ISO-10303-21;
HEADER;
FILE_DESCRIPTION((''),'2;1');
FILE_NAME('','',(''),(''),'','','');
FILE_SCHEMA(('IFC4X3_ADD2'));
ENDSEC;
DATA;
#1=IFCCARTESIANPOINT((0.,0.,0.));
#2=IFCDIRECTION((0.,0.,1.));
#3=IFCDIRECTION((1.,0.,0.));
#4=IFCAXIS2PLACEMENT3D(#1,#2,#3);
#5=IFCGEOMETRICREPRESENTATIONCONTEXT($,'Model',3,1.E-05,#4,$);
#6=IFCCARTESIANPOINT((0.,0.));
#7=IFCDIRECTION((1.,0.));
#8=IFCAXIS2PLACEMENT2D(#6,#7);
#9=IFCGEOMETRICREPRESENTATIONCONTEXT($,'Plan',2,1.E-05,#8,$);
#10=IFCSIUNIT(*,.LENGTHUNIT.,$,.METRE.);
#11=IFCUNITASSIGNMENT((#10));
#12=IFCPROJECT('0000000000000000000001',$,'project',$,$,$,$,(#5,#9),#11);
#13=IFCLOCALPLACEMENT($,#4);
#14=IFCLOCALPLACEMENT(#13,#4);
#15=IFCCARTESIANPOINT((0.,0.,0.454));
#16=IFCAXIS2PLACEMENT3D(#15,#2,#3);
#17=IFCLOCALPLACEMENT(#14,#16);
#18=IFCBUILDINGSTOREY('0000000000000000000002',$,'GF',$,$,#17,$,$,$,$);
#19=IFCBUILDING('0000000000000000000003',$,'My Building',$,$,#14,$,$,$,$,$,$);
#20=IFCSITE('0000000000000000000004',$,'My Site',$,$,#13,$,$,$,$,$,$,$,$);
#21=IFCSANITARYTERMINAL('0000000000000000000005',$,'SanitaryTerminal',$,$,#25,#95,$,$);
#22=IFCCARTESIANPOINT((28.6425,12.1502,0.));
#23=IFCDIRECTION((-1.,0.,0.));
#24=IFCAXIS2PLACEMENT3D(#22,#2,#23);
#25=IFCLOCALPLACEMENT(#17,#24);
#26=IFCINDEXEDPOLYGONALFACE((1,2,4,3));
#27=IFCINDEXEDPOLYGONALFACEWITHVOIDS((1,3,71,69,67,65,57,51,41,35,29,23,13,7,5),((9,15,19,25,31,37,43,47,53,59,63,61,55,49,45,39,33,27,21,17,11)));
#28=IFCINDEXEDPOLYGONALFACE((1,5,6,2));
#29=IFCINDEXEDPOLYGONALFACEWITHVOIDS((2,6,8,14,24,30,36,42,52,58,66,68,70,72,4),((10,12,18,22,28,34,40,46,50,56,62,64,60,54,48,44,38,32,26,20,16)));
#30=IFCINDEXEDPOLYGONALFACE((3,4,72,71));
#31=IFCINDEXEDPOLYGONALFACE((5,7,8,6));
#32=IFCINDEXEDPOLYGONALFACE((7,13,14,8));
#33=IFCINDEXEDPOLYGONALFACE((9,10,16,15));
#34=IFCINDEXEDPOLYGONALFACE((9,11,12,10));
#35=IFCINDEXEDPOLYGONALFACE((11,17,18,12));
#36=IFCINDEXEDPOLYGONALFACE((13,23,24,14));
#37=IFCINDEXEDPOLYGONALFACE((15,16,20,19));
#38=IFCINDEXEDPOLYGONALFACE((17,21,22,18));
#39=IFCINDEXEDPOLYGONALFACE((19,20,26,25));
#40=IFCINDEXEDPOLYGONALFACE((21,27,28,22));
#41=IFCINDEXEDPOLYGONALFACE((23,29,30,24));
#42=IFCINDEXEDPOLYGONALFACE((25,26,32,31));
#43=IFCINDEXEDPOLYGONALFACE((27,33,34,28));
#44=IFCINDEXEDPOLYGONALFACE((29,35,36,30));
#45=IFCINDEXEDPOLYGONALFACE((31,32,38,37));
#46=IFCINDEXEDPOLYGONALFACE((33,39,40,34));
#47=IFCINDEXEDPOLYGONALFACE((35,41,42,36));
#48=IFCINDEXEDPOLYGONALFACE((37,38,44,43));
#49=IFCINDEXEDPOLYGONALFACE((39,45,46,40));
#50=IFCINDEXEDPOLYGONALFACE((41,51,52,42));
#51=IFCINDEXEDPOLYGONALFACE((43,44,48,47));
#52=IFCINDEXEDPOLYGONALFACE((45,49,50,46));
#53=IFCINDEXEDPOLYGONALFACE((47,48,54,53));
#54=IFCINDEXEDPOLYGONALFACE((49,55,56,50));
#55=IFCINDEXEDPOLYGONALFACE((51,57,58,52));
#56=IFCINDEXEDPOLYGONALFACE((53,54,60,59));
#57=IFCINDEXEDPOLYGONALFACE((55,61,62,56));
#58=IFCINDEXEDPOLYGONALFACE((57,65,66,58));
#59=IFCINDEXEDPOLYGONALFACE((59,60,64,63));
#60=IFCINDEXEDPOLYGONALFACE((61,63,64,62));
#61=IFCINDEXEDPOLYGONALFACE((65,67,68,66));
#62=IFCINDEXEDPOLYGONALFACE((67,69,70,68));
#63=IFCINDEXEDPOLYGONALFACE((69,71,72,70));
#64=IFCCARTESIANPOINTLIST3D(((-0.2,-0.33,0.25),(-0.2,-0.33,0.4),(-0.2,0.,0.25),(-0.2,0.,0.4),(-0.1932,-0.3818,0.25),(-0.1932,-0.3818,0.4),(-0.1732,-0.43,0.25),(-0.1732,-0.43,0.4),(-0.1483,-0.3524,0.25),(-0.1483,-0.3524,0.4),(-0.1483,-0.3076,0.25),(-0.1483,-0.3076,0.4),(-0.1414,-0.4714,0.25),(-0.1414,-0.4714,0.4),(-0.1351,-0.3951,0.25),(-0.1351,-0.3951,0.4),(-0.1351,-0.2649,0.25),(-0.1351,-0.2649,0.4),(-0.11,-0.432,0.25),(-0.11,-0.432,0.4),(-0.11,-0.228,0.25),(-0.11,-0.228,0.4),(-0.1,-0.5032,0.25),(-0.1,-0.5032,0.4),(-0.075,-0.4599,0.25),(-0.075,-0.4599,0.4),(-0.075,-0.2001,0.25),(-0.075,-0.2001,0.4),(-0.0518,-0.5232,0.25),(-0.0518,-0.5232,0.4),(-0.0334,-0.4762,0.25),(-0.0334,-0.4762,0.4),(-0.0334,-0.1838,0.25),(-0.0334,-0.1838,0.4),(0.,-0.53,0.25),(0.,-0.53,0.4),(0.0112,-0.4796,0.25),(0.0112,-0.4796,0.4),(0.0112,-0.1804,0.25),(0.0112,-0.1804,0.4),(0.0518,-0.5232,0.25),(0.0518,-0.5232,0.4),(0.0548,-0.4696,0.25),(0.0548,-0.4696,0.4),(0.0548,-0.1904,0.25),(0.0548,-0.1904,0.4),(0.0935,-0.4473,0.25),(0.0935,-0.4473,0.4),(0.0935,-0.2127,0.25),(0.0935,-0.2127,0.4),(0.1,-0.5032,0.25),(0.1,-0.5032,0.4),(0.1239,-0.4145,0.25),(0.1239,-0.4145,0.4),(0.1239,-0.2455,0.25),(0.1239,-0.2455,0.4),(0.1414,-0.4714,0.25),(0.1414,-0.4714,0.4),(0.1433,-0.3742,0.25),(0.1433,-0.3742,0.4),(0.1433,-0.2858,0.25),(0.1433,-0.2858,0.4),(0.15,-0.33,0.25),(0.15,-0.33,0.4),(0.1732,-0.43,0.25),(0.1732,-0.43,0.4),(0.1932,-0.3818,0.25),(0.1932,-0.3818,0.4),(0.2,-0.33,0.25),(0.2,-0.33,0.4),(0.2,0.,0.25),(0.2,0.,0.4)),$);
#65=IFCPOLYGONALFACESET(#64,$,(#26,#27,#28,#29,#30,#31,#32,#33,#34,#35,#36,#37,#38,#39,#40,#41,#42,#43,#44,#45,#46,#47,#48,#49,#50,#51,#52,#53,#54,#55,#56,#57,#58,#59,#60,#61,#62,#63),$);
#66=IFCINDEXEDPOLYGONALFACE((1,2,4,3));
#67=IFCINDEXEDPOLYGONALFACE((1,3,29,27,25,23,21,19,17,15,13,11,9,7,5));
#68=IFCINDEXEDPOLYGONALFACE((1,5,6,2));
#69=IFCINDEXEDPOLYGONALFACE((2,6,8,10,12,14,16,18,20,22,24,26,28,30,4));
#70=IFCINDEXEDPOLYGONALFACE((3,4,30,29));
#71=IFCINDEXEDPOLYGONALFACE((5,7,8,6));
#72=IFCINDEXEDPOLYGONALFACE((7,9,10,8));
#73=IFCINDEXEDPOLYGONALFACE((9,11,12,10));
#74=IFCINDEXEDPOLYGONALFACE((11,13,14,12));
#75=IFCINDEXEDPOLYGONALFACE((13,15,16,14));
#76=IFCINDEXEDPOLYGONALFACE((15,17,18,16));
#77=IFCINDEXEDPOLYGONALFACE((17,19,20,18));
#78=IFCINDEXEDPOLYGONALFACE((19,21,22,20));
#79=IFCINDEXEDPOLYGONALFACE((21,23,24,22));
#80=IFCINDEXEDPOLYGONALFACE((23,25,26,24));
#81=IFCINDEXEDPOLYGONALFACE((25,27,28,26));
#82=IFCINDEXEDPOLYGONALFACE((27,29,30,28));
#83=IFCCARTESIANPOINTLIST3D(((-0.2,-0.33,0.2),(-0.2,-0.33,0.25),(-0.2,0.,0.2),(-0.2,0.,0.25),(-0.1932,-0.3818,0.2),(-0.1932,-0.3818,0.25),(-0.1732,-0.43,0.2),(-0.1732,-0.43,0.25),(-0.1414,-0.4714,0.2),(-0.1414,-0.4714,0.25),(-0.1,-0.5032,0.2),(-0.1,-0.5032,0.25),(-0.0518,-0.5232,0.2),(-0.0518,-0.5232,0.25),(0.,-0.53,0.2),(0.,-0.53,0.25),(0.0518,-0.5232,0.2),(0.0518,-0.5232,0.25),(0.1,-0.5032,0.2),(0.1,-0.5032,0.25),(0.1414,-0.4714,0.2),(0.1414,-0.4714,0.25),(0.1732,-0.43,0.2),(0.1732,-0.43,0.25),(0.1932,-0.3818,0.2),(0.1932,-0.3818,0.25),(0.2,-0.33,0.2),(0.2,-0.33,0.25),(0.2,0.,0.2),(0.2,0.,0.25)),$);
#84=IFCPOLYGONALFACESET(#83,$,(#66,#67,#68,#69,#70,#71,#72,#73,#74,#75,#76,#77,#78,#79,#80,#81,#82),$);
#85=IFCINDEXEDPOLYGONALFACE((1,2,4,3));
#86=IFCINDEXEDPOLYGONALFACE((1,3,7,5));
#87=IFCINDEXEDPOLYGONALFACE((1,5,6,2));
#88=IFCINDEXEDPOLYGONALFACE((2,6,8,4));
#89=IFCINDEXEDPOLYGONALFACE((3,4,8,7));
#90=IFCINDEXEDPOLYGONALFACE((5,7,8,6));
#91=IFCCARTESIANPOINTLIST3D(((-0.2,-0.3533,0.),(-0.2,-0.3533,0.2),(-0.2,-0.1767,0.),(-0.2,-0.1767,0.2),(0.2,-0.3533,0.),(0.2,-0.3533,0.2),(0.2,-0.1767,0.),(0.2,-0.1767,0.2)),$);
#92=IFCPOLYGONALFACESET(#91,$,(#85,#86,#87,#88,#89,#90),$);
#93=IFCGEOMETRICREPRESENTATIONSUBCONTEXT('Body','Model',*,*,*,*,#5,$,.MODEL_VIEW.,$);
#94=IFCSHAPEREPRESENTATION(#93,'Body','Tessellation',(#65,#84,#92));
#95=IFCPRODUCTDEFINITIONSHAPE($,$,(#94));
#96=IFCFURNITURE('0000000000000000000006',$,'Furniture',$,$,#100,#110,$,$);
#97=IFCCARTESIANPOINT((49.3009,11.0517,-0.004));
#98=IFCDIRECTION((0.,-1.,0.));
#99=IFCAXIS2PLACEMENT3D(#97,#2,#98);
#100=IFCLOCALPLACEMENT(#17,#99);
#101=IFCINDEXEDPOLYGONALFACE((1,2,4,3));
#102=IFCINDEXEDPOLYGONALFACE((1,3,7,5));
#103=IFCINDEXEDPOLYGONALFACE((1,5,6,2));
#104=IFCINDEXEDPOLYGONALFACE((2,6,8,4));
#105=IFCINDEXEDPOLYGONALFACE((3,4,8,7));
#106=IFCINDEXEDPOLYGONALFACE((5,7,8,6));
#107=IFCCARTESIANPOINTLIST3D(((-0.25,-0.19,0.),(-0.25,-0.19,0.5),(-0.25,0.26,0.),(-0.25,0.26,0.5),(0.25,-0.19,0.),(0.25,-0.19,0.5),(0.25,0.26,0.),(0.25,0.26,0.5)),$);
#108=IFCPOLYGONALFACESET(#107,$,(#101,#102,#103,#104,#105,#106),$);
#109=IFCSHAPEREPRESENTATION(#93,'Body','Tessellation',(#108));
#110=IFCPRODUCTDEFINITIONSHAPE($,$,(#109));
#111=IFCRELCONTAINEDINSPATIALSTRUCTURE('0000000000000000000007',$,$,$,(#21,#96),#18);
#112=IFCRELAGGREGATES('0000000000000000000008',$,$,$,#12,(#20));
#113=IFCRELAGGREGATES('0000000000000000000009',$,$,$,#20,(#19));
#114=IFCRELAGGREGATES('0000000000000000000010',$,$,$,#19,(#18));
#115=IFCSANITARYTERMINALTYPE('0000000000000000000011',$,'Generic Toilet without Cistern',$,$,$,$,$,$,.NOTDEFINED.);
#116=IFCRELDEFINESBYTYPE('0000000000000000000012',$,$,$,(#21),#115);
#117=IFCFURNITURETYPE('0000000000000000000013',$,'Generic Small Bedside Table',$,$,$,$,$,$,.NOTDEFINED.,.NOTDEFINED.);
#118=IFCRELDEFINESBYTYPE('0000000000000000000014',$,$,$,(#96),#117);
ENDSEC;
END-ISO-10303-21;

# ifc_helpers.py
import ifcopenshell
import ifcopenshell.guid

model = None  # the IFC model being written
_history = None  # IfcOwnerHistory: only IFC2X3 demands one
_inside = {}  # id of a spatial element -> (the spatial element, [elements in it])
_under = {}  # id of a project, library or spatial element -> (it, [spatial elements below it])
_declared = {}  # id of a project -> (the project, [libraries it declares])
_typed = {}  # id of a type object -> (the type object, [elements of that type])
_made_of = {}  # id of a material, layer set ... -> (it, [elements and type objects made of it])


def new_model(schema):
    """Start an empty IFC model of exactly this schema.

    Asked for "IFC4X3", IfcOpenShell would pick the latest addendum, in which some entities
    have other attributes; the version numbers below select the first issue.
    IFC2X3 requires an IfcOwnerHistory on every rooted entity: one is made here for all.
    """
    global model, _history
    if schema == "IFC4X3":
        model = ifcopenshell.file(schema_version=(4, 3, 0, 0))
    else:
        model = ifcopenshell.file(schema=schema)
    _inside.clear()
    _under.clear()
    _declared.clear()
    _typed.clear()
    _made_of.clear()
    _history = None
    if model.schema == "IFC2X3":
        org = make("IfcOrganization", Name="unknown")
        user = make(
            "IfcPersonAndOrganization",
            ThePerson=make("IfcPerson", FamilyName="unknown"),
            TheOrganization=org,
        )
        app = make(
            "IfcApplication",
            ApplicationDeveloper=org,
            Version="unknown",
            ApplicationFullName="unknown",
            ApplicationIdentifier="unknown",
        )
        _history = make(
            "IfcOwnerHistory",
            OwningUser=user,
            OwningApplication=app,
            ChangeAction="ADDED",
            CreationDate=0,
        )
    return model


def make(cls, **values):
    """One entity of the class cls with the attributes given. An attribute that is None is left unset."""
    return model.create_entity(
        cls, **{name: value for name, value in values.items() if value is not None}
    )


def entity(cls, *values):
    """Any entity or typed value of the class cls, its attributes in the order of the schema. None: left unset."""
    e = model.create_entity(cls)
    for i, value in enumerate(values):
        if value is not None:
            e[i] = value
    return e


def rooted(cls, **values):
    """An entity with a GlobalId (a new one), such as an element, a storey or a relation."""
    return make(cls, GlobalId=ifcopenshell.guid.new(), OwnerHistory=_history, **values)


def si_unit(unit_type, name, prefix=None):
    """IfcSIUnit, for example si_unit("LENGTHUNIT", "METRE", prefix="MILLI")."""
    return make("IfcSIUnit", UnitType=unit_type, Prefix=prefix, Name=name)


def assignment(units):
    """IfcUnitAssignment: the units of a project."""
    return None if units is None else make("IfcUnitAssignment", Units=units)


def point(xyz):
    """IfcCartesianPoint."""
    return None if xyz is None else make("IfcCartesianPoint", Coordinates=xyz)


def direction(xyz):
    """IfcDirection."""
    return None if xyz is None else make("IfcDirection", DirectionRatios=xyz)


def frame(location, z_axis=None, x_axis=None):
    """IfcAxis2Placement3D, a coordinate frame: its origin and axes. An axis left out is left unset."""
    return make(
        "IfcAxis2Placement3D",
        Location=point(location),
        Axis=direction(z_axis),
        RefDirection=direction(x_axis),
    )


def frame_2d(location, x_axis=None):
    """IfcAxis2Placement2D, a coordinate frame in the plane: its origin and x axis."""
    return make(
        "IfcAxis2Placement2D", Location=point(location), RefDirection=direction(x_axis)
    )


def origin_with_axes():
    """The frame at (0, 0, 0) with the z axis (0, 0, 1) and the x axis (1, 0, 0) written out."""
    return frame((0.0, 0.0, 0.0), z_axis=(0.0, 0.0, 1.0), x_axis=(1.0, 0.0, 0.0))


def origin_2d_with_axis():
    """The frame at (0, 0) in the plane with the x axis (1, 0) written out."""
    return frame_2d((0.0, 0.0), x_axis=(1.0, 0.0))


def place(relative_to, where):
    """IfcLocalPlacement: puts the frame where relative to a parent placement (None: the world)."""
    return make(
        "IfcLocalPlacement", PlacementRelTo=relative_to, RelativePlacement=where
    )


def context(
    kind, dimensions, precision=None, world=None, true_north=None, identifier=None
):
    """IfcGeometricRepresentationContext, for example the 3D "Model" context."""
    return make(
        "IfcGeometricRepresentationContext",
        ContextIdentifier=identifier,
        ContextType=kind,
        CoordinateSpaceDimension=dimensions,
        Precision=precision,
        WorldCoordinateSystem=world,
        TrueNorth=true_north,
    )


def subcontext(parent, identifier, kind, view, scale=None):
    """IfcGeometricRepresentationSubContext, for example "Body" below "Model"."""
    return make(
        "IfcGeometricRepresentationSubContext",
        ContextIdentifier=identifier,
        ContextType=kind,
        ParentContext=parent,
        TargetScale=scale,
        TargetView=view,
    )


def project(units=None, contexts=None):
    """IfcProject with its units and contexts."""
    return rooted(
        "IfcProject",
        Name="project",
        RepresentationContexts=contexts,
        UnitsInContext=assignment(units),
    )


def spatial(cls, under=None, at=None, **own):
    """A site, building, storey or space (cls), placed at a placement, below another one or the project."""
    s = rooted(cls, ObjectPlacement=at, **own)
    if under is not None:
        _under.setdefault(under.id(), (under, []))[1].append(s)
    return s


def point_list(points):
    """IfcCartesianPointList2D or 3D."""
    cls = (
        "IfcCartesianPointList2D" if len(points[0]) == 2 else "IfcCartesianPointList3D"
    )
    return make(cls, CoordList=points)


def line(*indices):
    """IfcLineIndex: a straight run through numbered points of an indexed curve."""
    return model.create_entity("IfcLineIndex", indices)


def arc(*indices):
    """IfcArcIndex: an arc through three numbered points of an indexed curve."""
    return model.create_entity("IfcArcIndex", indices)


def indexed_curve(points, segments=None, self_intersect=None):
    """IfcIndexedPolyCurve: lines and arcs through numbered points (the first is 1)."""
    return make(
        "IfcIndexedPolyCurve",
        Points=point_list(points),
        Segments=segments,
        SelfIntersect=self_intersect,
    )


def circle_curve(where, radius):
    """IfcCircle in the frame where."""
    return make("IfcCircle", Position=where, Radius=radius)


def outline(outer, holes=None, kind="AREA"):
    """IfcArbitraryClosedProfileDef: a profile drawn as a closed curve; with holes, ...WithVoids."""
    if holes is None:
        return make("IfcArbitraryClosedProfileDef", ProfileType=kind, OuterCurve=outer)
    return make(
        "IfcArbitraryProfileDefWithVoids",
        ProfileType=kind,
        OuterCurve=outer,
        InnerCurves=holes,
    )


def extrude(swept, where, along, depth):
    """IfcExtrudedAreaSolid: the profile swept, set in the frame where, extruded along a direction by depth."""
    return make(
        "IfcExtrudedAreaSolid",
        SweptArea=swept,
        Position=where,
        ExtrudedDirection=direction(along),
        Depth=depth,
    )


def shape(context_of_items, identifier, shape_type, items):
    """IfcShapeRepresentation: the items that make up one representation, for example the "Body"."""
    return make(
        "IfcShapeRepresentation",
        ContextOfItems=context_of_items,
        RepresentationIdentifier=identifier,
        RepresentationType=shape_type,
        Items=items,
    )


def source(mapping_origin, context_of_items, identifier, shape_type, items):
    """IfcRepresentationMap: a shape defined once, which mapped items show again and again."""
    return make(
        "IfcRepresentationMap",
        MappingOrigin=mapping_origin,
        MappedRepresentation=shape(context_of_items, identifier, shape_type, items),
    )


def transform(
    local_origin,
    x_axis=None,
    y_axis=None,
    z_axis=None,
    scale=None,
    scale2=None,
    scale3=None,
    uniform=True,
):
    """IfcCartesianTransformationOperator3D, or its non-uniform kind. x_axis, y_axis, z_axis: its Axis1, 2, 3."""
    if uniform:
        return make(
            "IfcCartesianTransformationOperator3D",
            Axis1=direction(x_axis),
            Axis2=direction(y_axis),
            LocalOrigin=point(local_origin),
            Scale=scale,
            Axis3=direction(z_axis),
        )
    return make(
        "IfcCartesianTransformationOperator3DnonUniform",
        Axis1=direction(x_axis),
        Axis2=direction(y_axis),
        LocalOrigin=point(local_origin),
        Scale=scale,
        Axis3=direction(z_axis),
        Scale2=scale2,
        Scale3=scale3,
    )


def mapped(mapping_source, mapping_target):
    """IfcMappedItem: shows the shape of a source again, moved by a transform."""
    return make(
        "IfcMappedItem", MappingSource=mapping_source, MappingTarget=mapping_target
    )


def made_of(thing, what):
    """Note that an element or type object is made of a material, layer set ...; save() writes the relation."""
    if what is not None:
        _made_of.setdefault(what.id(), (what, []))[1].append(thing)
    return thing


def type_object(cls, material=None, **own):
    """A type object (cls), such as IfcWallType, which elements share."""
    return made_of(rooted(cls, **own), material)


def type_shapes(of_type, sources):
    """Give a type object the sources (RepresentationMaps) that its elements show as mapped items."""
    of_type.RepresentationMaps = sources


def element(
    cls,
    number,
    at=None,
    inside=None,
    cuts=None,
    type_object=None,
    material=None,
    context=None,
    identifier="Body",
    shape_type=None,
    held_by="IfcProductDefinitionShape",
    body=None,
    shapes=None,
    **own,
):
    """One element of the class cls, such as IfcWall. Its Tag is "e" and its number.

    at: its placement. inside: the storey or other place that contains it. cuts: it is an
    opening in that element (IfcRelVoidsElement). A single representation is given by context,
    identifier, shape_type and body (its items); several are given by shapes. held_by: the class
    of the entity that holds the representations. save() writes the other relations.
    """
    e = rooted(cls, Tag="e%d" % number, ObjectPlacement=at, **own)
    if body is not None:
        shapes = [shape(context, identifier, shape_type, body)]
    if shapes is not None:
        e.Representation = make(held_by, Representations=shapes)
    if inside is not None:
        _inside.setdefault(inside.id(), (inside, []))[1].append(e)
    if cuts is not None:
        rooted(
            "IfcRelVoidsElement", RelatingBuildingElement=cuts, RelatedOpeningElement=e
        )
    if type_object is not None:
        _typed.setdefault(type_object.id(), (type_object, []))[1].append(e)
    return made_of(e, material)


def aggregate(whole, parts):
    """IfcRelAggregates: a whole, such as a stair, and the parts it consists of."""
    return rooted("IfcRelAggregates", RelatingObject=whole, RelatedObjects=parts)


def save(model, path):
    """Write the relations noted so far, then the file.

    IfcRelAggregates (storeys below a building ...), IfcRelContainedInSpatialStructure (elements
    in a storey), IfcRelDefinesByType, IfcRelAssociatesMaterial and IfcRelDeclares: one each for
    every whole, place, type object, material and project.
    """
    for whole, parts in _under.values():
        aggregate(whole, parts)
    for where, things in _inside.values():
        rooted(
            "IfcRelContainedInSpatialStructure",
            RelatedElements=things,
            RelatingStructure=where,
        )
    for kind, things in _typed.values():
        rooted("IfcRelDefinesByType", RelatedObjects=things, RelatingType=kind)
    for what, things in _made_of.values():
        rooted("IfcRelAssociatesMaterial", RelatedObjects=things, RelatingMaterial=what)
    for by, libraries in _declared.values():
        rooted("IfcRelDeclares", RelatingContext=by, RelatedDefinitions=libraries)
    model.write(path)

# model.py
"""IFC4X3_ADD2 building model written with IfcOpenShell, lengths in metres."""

from ifc_helpers import new_model, entity, si_unit, frame, frame_2d, origin_with_axes, origin_2d_with_axis, place, context, subcontext, project, spatial, line, arc, indexed_curve, circle_curve, outline, extrude, shape, source, transform, mapped, type_object, type_shapes, element, save


model = new_model("IFC4X3_ADD2")

# Units and contexts
model_context = context("Model", 3, precision=1e-05, world=origin_with_axes())
plan_context = context("Plan", 2, precision=1e-05, world=origin_2d_with_axis())
body_context_1 = subcontext(model_context, "Body", "Model", "MODEL_VIEW")
body_context_2 = subcontext(plan_context, "Body", "Plan", "PLAN_VIEW")
ifc_project = project(units=[si_unit("LENGTHUNIT", "METRE")], contexts=[model_context, plan_context])

# Site, building, storey
site_placement = place(None, origin_with_axes())
site = spatial("IfcSite", under=ifc_project, at=site_placement, Name="My Site")
building_placement = place(site_placement, origin_with_axes())
building = spatial("IfcBuilding", under=site, at=building_placement, Name="My Building")
storey_placement = place(building_placement, frame((0.0, 0.0, 0.454), z_axis=(0.0, 0.0, 1.0), x_axis=(1.0, 0.0, 0.0)))
storey = spatial("IfcBuildingStorey", under=building, at=storey_placement, Name="GF")

# Sanitary terminal
sanitary_terminal_type = type_object("IfcSanitaryTerminalType", Name="Generic Toilet without Cistern", PredefinedType="NOTDEFINED")
shared_shape_1 = source(origin_with_axes(), body_context_1, "Body", "SweptSolid", [
    extrude(outline(indexed_curve([(-0.2, 0.0), (0.2, 0.0), (0.2, -0.33), (0.1414, -0.4714), (0.0, -0.53), (-0.1414, -0.4714), (-0.2, -0.33)], segments=[line(1, 2), line(2, 3), arc(3, 4, 5), arc(5, 6, 7), line(7, 1)]), holes=[circle_curve(frame_2d((0.0, -0.33)), 0.15)]), frame((0.0, 0.0, 0.25), z_axis=(0.0, 0.0, 1.0), x_axis=(1.0, 0.0, 0.0)), (0.0, 0.0, 1.0), 0.15),
    extrude(outline(indexed_curve([(-0.2, 0.0), (0.2, 0.0), (0.2, -0.33), (0.1414, -0.4714), (0.0, -0.53), (-0.1414, -0.4714), (-0.2, -0.33)], segments=[line(1, 2), line(2, 3), arc(3, 4, 5), arc(5, 6, 7), line(7, 1)])), frame((0.0, 0.0, 0.2), z_axis=(0.0, 0.0, 1.0), x_axis=(1.0, 0.0, 0.0)), (0.0, 0.0, 1.0), 0.05),
    extrude(outline(indexed_curve([(-0.2, -0.1767), (0.2, -0.1767), (0.2, -0.3533), (-0.2, -0.3533)], segments=[line(1, 2, 3, 4, 1)])), origin_with_axes(), (0.0, 0.0, 1.0), 0.2),
])
shared_shape_2 = source(origin_with_axes(), body_context_2, "Body", "Annotation2D", [
    entity("IfcGeometricCurveSet", [entity("IfcIndexedPolyCurve", entity("IfcCartesianPointList2D", [[-0.1068, -0.124], [-0.0957, -0.1129], [-0.0804, -0.1088], [0.0804, -0.1088], [0.0957, -0.1129], [0.1068, -0.124], [0.1109, -0.1393], [0.1109, -0.3476], [0.1025, -0.3926], [0.0784, -0.4308], [0.0424, -0.4563], [0.0, -0.4652], [-0.0424, -0.4563], [-0.0784, -0.4308], [-0.1025, -0.3926], [-0.1109, -0.3476], [-0.1109, -0.1393]]), [entity("IfcLineIndex", [1, 2, 3, 4, 5, 6, 7, 8, 9, 10, 11, 12, 13, 14, 15, 16, 17, 1])]), entity("IfcIndexedPolyCurve", entity("IfcCartesianPointList2D", [[-0.1962, -0.2314], [-0.1848, -0.301], [-0.1764, -0.3339], [-0.1663, -0.3651], [-0.1546, -0.3944], [-0.1414, -0.4213], [-0.1269, -0.4458], [-0.1111, -0.4675], [-0.0943, -0.4862], [-0.0765, -0.5018], [-0.0581, -0.514], [-0.039, -0.5229], [-0.0196, -0.5282], [0.0, -0.53], [0.0196, -0.5282], [0.039, -0.5229], [0.0581, -0.514], [0.0765, -0.5018], [0.0943, -0.4862], [0.1111, -0.4675], [0.1269, -0.4458], [0.1414, -0.4213], [0.1546, -0.3944], [0.1663, -0.3651], [0.1764, -0.3339], [0.1848, -0.301], [0.1962, -0.2314], [0.2, -0.159], [0.1872, 0.0], [-0.1872, 0.0], [-0.2, -0.159]]), [entity("IfcLineIndex", [1, 2, 3, 4, 5, 6, 7, 8, 9, 10, 11, 12, 13, 14, 15, 16, 17, 18, 19, 20, 21, 22, 23, 24, 25, 26, 27, 28, 29, 30, 31, 1])])]),
])
type_shapes(sanitary_terminal_type, [shared_shape_1, shared_shape_2])
sanitary_terminal_placement = place(storey_placement, frame((28.6425, 12.1502, 0.0), z_axis=(0.0, 0.0, 1.0), x_axis=(-1.0, 0.0, 0.0)))
element("IfcSanitaryTerminal", 1, at=sanitary_terminal_placement, inside=storey, type_object=sanitary_terminal_type, Name="SanitaryTerminal", shapes=[
    shape(body_context_1, "Body", "MappedRepresentation", [mapped(shared_shape_1, transform((0.0, 0.0, 0.0), x_axis=(1.0, 0.0, 0.0), y_axis=(0.0, 1.0, 0.0), z_axis=(0.0, 0.0, 1.0), scale=1.0))]),
    shape(body_context_2, "Body", "MappedRepresentation", [mapped(shared_shape_2, transform((0.0, 0.0, 0.0), x_axis=(1.0, 0.0, 0.0), y_axis=(0.0, 1.0, 0.0), z_axis=(0.0, 0.0, 1.0), scale=1.0))]),
])

# Furniture
furniture_type_1 = type_object("IfcFurnitureType", Name="Generic Small Bedside Table", AssemblyPlace="NOTDEFINED", PredefinedType="NOTDEFINED")
shared_shape_3 = source(origin_with_axes(), body_context_1, "Body", "SweptSolid", [
    extrude(outline(indexed_curve([(0.5, 0.45), (0.5, 0.0), (0.0, 0.0), (0.0, 0.45)], segments=[line(4, 1), line(1, 2), line(2, 3), line(3, 4)], self_intersect=False)), frame((-0.25, -0.19, 0.0), z_axis=(0.0, 0.0, 1.0), x_axis=(1.0, 0.0, 0.0)), (0.0, 0.0, 1.0), 0.5),
])
shared_shape_4 = source(origin_with_axes(), body_context_2, "Body", "Annotation2D", [
    entity("IfcGeometricCurveSet", [entity("IfcIndexedPolyCurve", entity("IfcCartesianPointList2D", [[-0.25, -0.19], [0.25, -0.19], [0.25, 0.26], [-0.25, 0.26]]), [entity("IfcLineIndex", [1, 2]), entity("IfcLineIndex", [2, 3]), entity("IfcLineIndex", [3, 4]), entity("IfcLineIndex", [4, 1])])]),
])
type_shapes(furniture_type_1, [shared_shape_3, shared_shape_4])
furniture_1_placement = place(storey_placement, frame((49.3009, 11.0517, -0.004), z_axis=(0.0, 0.0, 1.0), x_axis=(0.0, -1.0, 0.0)))
element("IfcFurniture", 2, at=furniture_1_placement, inside=storey, type_object=furniture_type_1, Name="Furniture", shapes=[
    shape(body_context_1, "Body", "MappedRepresentation", [mapped(shared_shape_3, transform((0.0, 0.0, 0.0), x_axis=(1.0, 0.0, 0.0), y_axis=(0.0, 1.0, 0.0), z_axis=(0.0, 0.0, 1.0), scale=1.0))]),
    shape(body_context_2, "Body", "MappedRepresentation", [mapped(shared_shape_4, transform((0.0, 0.0, 0.0), x_axis=(1.0, 0.0, 0.0), y_axis=(0.0, 1.0, 0.0), z_axis=(0.0, 0.0, 1.0), scale=1.0))]),
])

save(model, "model.ifc")
